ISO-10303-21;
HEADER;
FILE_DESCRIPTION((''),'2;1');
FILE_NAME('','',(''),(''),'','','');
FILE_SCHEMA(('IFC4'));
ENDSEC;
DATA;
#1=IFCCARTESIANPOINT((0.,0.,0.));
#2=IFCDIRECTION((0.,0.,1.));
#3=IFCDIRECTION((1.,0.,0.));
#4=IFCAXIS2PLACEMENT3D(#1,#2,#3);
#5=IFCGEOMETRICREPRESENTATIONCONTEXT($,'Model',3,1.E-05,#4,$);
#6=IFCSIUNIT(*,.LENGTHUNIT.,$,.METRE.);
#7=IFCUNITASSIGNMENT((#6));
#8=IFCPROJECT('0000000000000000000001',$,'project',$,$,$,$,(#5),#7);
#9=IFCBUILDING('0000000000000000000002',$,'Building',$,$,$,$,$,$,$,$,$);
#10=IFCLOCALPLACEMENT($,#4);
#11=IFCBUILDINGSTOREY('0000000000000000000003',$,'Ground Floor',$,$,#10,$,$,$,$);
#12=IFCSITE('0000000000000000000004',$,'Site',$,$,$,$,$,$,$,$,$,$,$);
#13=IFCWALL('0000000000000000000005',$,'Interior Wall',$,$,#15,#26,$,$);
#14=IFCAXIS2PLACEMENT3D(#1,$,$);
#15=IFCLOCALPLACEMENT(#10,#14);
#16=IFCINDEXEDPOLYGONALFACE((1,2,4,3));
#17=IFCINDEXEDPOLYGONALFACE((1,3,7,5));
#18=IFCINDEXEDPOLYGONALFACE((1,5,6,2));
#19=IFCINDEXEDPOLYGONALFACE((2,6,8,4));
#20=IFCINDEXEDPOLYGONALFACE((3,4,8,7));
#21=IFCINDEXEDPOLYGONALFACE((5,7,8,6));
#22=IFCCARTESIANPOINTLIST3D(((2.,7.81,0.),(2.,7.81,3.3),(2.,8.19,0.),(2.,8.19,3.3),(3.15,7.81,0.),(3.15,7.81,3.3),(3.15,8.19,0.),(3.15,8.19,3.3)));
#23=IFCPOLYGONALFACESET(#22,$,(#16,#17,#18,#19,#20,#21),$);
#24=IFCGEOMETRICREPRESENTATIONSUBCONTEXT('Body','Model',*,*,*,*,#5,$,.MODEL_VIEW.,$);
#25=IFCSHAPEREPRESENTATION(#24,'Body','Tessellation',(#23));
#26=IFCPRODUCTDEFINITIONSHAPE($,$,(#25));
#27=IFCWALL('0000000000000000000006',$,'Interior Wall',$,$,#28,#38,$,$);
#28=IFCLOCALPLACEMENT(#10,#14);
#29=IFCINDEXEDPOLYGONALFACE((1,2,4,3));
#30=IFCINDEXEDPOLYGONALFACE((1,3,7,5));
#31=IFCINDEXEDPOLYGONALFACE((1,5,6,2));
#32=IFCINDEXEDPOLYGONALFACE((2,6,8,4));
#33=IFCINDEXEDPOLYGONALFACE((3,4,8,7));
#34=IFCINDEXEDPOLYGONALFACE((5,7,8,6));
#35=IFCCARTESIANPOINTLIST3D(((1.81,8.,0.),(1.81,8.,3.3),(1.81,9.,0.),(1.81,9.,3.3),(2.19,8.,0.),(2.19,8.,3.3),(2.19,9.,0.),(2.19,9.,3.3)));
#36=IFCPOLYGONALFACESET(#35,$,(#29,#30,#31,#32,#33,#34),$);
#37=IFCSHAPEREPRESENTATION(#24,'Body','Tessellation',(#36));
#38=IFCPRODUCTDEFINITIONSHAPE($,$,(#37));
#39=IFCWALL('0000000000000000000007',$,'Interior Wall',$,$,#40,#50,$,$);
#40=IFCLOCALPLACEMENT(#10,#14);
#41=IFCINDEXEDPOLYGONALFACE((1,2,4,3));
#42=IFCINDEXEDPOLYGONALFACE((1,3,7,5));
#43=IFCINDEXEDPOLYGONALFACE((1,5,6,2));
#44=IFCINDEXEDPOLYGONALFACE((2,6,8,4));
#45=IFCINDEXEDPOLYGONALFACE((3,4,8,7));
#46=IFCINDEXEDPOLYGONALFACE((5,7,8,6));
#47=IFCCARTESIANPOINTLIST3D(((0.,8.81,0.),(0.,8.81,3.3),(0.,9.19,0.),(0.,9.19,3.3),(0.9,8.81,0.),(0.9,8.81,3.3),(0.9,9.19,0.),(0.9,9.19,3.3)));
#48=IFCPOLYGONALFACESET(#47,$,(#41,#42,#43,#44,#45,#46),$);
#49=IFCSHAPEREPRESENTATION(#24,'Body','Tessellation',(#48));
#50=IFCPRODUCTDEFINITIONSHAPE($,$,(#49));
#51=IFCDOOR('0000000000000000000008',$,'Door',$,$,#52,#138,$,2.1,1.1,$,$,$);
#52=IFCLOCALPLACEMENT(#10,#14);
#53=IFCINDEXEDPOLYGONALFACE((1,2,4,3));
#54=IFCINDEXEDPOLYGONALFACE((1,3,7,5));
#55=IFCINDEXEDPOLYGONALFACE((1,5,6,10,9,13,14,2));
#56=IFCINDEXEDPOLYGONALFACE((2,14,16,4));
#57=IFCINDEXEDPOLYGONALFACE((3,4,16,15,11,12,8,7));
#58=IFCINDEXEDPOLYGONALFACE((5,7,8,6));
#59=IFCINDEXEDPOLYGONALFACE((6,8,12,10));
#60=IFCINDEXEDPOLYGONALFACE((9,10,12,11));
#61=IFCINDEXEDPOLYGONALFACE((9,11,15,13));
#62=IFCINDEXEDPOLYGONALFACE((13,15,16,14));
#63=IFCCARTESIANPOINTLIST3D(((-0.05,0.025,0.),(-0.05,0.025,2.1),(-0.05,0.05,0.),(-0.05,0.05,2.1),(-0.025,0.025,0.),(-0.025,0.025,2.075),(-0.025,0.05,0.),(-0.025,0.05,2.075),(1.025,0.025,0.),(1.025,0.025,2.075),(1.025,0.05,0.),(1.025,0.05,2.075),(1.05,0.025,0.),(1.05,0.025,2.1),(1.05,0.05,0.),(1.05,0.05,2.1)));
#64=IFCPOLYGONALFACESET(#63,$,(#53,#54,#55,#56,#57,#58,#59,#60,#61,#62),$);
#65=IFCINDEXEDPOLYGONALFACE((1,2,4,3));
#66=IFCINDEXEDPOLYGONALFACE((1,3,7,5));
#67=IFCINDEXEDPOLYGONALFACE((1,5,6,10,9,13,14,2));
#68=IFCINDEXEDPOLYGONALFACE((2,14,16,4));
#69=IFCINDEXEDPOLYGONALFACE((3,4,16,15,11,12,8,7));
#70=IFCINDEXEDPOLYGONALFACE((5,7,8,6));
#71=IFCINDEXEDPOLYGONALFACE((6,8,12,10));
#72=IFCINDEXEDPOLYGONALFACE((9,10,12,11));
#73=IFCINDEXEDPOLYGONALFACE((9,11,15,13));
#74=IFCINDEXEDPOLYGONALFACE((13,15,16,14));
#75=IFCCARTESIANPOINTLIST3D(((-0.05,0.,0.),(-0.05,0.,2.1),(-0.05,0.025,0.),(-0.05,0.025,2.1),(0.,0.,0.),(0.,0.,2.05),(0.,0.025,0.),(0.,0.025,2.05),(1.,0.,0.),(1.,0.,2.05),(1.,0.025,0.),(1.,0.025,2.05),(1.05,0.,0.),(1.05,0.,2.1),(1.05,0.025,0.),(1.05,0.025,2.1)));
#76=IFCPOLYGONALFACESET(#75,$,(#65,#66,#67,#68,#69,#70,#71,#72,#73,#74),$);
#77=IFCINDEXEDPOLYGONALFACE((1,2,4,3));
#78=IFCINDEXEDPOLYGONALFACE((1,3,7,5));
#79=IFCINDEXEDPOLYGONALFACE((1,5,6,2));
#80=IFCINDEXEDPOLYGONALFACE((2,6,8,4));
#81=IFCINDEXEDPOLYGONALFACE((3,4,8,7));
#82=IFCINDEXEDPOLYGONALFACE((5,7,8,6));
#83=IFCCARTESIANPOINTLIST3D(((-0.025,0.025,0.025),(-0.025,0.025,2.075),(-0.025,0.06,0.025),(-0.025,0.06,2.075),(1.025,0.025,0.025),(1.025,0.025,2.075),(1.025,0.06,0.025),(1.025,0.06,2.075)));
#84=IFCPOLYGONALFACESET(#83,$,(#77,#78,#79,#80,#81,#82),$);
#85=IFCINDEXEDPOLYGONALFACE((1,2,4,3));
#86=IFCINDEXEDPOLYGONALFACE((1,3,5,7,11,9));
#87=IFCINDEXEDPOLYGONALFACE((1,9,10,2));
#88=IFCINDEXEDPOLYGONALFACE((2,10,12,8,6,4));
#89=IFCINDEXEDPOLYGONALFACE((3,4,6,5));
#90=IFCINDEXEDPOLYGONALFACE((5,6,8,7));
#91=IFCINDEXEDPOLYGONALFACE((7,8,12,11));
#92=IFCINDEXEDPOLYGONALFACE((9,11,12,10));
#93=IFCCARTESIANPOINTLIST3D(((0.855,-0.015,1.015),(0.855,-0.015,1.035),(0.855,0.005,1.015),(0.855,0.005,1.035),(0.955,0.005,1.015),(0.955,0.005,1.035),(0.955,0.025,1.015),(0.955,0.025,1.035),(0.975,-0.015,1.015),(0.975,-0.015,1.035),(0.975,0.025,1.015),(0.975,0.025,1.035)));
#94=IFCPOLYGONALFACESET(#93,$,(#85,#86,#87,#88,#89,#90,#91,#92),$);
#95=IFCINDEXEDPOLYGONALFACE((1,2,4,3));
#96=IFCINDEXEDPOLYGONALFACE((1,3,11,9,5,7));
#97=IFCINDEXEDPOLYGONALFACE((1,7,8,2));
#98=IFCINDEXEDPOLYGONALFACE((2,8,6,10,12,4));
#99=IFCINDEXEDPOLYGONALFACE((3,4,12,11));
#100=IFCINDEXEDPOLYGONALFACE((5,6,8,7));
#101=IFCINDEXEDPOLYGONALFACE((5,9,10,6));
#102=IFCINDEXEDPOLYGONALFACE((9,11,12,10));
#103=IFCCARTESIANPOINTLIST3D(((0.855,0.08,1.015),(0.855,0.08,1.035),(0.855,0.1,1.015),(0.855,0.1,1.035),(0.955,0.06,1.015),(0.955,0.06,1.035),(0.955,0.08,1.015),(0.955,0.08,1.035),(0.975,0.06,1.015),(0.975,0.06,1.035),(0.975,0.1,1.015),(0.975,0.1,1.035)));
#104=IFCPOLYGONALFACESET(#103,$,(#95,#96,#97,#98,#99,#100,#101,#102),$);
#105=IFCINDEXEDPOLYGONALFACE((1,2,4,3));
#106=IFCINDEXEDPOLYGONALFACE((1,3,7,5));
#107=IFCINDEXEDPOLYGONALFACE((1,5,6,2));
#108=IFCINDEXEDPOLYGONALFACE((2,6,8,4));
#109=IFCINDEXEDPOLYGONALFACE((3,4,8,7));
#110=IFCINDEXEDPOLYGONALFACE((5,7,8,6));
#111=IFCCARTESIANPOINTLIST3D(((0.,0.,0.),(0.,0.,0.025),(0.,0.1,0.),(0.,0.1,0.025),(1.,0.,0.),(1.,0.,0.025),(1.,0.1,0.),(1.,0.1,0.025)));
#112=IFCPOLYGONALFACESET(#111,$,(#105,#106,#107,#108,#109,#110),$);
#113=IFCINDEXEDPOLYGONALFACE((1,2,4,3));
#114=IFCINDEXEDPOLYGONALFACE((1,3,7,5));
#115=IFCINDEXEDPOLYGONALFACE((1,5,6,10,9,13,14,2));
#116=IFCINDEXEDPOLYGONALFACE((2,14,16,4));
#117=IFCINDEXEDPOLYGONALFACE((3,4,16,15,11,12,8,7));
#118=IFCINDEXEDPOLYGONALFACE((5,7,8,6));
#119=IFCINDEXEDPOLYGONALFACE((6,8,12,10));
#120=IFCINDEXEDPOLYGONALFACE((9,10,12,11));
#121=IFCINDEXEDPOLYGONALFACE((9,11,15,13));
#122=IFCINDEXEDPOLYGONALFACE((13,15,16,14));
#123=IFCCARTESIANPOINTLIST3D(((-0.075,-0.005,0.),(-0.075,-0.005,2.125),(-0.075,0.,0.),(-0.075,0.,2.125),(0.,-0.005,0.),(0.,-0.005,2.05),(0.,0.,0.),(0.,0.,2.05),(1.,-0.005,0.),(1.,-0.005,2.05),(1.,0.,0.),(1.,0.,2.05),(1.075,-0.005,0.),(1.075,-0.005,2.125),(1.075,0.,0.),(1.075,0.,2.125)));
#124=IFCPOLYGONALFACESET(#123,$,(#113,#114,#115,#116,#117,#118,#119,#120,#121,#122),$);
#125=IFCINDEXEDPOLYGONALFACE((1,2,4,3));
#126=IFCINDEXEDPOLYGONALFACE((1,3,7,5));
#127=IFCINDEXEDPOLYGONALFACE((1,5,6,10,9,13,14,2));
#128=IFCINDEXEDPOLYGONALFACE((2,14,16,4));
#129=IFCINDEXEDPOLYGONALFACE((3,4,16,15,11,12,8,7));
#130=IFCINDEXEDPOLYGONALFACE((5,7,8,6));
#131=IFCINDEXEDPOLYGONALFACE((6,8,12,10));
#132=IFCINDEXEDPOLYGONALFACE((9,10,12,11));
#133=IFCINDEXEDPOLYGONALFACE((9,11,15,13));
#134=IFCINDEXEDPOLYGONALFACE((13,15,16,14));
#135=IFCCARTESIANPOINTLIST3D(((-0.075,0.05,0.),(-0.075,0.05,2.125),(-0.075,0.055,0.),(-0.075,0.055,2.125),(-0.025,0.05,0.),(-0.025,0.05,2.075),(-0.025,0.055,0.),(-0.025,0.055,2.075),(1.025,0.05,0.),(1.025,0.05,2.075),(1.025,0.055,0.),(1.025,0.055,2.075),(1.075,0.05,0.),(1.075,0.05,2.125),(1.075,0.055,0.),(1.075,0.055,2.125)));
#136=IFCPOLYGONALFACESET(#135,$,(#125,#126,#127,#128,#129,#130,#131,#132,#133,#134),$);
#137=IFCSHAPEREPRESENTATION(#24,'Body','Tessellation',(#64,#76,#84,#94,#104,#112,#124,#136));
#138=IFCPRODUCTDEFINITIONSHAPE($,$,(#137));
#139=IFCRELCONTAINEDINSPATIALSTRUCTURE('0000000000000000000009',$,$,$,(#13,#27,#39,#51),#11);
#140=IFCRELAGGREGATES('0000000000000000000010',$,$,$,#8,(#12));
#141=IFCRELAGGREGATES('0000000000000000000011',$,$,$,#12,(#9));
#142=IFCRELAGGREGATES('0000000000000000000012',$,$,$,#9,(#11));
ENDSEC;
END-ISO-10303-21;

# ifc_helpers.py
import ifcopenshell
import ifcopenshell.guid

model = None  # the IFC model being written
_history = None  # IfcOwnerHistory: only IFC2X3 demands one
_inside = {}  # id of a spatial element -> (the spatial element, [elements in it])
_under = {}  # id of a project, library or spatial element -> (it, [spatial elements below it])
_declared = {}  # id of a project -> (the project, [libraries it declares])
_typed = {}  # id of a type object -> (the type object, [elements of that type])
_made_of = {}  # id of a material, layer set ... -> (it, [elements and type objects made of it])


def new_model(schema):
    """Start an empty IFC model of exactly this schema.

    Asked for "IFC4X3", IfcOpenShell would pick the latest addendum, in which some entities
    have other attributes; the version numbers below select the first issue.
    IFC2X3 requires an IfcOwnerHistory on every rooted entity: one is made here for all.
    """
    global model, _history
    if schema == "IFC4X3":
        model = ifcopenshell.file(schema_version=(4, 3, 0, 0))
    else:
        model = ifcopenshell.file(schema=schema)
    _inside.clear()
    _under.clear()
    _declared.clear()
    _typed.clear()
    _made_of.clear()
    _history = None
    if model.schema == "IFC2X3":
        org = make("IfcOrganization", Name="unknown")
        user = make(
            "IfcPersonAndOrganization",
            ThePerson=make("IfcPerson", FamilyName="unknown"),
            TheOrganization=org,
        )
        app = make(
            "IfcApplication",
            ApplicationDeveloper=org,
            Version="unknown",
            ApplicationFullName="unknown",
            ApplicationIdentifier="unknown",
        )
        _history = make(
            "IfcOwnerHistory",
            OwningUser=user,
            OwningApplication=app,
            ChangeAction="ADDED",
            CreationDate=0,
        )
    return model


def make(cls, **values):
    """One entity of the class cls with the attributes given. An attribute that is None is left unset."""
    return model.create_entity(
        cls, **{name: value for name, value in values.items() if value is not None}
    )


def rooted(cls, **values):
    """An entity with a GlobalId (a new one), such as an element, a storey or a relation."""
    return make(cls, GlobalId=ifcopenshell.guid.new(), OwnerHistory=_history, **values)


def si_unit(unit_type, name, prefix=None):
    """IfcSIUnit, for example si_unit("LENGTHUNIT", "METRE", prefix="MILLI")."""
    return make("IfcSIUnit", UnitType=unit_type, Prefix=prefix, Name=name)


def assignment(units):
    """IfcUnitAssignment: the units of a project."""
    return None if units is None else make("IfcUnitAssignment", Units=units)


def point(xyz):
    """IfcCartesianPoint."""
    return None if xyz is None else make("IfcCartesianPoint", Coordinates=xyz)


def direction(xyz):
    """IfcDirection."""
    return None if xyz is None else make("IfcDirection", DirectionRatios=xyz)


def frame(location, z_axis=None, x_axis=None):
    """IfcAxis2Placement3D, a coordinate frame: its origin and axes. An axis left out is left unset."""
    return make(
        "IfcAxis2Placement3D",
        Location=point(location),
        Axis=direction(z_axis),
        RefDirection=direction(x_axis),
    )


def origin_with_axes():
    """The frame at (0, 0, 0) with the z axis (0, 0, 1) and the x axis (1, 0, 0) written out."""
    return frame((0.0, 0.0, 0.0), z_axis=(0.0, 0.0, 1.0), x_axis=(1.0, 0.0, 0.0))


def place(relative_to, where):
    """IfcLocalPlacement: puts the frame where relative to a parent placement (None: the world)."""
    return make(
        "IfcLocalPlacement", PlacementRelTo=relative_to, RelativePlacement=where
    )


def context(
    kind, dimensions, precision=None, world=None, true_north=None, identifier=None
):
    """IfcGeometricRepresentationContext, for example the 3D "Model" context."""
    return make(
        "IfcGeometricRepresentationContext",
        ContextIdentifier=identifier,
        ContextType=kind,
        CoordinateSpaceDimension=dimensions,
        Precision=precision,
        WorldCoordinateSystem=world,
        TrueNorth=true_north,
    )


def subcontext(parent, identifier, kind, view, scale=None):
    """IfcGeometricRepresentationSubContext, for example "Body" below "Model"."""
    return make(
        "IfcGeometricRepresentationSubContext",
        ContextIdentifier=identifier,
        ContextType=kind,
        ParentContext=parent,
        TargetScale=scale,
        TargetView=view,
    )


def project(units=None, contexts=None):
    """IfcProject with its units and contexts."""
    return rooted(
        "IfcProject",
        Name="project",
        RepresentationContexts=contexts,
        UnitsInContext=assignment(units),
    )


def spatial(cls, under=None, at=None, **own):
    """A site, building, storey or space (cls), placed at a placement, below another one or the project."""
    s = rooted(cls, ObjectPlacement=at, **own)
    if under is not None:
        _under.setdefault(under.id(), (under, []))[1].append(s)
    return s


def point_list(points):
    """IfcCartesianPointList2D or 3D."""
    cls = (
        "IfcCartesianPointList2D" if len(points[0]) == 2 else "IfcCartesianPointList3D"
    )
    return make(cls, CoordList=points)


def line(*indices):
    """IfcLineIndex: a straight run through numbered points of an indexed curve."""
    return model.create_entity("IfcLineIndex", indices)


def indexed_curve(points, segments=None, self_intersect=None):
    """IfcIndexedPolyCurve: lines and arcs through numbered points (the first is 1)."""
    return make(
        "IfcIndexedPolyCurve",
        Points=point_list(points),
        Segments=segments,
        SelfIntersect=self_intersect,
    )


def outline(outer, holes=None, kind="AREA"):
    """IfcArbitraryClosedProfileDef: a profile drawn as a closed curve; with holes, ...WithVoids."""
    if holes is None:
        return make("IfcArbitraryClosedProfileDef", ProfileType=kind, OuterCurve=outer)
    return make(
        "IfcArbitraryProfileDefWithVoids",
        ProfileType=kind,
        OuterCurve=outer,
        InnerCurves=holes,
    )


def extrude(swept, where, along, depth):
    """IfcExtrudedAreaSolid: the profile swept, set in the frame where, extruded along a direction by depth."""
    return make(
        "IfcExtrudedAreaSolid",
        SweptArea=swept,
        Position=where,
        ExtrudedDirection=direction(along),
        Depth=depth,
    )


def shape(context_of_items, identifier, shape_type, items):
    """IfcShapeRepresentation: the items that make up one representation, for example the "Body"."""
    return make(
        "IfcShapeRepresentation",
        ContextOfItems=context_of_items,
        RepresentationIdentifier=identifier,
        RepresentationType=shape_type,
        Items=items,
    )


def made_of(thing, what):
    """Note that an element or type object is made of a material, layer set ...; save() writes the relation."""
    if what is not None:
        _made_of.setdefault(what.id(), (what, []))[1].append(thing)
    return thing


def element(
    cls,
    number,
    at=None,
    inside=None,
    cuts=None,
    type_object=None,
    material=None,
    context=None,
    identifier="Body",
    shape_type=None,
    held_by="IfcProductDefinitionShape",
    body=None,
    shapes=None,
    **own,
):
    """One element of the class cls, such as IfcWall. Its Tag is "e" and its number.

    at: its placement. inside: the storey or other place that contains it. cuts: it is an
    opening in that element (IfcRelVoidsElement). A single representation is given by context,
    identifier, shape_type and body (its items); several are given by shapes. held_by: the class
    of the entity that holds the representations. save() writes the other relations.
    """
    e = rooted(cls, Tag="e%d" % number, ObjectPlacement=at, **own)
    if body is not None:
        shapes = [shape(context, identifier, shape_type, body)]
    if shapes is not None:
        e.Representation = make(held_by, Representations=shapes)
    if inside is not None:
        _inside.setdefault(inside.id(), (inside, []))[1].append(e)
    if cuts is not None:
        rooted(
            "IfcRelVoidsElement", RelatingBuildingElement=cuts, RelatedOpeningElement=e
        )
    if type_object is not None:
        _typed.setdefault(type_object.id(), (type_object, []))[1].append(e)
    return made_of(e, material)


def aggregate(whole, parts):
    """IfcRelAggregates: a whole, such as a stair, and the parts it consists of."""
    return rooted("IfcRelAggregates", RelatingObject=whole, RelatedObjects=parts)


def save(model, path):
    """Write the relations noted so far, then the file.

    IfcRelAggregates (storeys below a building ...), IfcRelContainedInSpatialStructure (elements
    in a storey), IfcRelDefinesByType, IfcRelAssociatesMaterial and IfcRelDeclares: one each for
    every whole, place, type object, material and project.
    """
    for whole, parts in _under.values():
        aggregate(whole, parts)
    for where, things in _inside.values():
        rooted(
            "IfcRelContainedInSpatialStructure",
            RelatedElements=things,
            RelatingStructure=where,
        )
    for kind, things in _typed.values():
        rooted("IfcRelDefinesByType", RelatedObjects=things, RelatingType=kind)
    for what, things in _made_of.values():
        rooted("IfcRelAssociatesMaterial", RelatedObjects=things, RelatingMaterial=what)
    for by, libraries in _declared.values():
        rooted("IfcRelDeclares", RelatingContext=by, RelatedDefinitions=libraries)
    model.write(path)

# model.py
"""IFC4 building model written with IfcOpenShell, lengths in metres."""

from ifc_helpers import new_model, si_unit, frame, origin_with_axes, place, context, subcontext, project, spatial, line, indexed_curve, outline, extrude, element, save


model = new_model("IFC4")

# Units and contexts
model_context = context("Model", 3, precision=1e-05, world=origin_with_axes())
body_context = subcontext(model_context, "Body", "Model", "MODEL_VIEW")
ifc_project = project(units=[si_unit("LENGTHUNIT", "METRE")], contexts=[model_context])

# Site, building, storey
site = spatial("IfcSite", under=ifc_project, Name="Site")
building = spatial("IfcBuilding", under=site, Name="Building")
storey_placement = place(None, origin_with_axes())
storey = spatial("IfcBuildingStorey", under=building, at=storey_placement, Name="Ground Floor")

# Walls
wall_1_placement = place(storey_placement, frame((3.15, 8.0, 0.0), z_axis=(0.0, 0.0, 1.0), x_axis=(-1.0, 0.0, 0.0)))
element("IfcWall", 1, at=wall_1_placement, inside=storey, Name="Interior Wall", context=body_context, shape_type="SweptSolid", body=[
    extrude(outline(indexed_curve([(0.0, 0.0), (0.0, 0.38), (1.15, 0.38), (1.15, 0.0), (0.0, 0.0)], self_intersect=False)), frame((0.0, -0.19, 0.0), z_axis=(0.0, 0.0, 1.0), x_axis=(1.0, 0.0, 0.0)), (0.0, 0.0, 1.0), 3.3),
])
wall_2_placement = place(storey_placement, frame((2.0, 8.0, 0.0), z_axis=(0.0, 0.0, 1.0), x_axis=(0.0, 1.0, 0.0)))
element("IfcWall", 2, at=wall_2_placement, inside=storey, Name="Interior Wall", context=body_context, shape_type="SweptSolid", body=[
    extrude(outline(indexed_curve([(0.0, 0.0), (0.0, 0.38), (1.0, 0.38), (1.0, 0.0), (0.0, 0.0)], self_intersect=False)), frame((0.0, -0.19, 0.0), z_axis=(0.0, 0.0, 1.0), x_axis=(1.0, 0.0, 0.0)), (0.0, 0.0, 1.0), 3.3),
])
wall_3_placement = place(storey_placement, frame((0.9, 9.0, 0.0), z_axis=(0.0, 0.0, 1.0), x_axis=(-1.0, 0.0, 0.0)))
element("IfcWall", 3, at=wall_3_placement, inside=storey, Name="Interior Wall", context=body_context, shape_type="SweptSolid", body=[
    extrude(outline(indexed_curve([(0.0, 0.0), (0.0, 0.38), (0.9, 0.38), (0.9, 0.0), (0.0, 0.0)], self_intersect=False)), frame((0.0, -0.19, 0.0), z_axis=(0.0, 0.0, 1.0), x_axis=(1.0, 0.0, 0.0)), (0.0, 0.0, 1.0), 3.3),
])

# Door
door_1_placement = place(storey_placement, frame((-0.05, 0.0, 0.0), z_axis=(0.0, 0.0, 1.0), x_axis=(1.0, 0.0, 0.0)))
element("IfcDoor", 4, at=door_1_placement, inside=storey, Name="Door", OverallHeight=2.1, OverallWidth=1.1, context=body_context, shape_type="SweptSolid", body=[
    extrude(outline(indexed_curve([(0.0, 0.0), (0.0, 2.1), (1.1, 2.1), (1.1, 0.0), (1.075, 0.0), (1.075, 2.075), (0.025, 2.075), (0.025, 0.0)], segments=[line(1, 2, 3, 4, 5, 6, 7, 8, 1)])), frame((0.0, 0.025, 0.0), z_axis=(0.0, -1.0, 0.0), x_axis=(1.0, 0.0, 0.0)), (0.0, 0.0, -1.0), 0.025),
    extrude(outline(indexed_curve([(0.0, 0.0), (0.0, 2.1), (1.1, 2.1), (1.1, 0.0), (1.05, 0.0), (1.05, 2.05), (0.05, 2.05), (0.05, 0.0)], segments=[line(1, 2, 3, 4, 5, 6, 7, 8, 1)])), frame((0.0, 0.0, 0.0), z_axis=(0.0, -1.0, 0.0), x_axis=(1.0, 0.0, 0.0)), (0.0, 0.0, -1.0), 0.025),
    extrude(outline(indexed_curve([(0.0, 0.0), (1.05, 0.0), (1.05, 0.035), (0.0, 0.035)], segments=[line(1, 2, 3, 4, 1)])), frame((0.025, 0.025, 0.025), z_axis=(0.0, 0.0, 1.0), x_axis=(1.0, 0.0, 0.0)), (0.0, 0.0, 1.0), 2.05),
    extrude(outline(indexed_curve([(0.0, 0.0), (0.0, -0.04), (-0.12, -0.04), (-0.12, -0.02), (-0.02, -0.02), (-0.02, 0.0)], segments=[line(1, 2, 3, 4, 5, 6, 1)])), frame((1.025, 0.025, 1.015), z_axis=(0.0, 0.0, 1.0), x_axis=(1.0, 0.0, 0.0)), (0.0, 0.0, 1.0), 0.02),
    extrude(outline(indexed_curve([(0.0, 0.0), (0.0, 0.04), (-0.12, 0.04), (-0.12, 0.02), (-0.02, 0.02), (-0.02, 0.0)], segments=[line(1, 2, 3, 4, 5, 6, 1)])), frame((1.025, 0.06, 1.015), z_axis=(0.0, 0.0, 1.0), x_axis=(1.0, 0.0, 0.0)), (0.0, 0.0, 1.0), 0.02),
    extrude(outline(indexed_curve([(0.0, 0.0), (1.0, 0.0), (1.0, 0.1), (0.0, 0.1)], segments=[line(1, 2, 3, 4, 1)])), frame((0.05, 0.0, 0.0), z_axis=(0.0, 0.0, 1.0), x_axis=(1.0, 0.0, 0.0)), (0.0, 0.0, 1.0), 0.025),
    extrude(outline(indexed_curve([(0.0, 0.0), (0.0, 2.125), (1.15, 2.125), (1.15, 0.0), (1.075, 0.0), (1.075, 2.05), (0.075, 2.05), (0.075, 0.0)], segments=[line(1, 2, 3, 4, 5, 6, 7, 8, 1)])), frame((-0.025, -0.005, 0.0), z_axis=(0.0, -1.0, 0.0), x_axis=(1.0, 0.0, 0.0)), (0.0, 0.0, -1.0), 0.005),
    extrude(outline(indexed_curve([(0.0, 0.0), (0.0, 2.125), (1.15, 2.125), (1.15, 0.0), (1.1, 0.0), (1.1, 2.075), (0.05, 2.075), (0.05, 0.0)], segments=[line(1, 2, 3, 4, 5, 6, 7, 8, 1)])), frame((-0.025, 0.05, 0.0), z_axis=(0.0, -1.0, 0.0), x_axis=(1.0, 0.0, 0.0)), (0.0, 0.0, -1.0), 0.005),
])

save(model, "model.ifc")
